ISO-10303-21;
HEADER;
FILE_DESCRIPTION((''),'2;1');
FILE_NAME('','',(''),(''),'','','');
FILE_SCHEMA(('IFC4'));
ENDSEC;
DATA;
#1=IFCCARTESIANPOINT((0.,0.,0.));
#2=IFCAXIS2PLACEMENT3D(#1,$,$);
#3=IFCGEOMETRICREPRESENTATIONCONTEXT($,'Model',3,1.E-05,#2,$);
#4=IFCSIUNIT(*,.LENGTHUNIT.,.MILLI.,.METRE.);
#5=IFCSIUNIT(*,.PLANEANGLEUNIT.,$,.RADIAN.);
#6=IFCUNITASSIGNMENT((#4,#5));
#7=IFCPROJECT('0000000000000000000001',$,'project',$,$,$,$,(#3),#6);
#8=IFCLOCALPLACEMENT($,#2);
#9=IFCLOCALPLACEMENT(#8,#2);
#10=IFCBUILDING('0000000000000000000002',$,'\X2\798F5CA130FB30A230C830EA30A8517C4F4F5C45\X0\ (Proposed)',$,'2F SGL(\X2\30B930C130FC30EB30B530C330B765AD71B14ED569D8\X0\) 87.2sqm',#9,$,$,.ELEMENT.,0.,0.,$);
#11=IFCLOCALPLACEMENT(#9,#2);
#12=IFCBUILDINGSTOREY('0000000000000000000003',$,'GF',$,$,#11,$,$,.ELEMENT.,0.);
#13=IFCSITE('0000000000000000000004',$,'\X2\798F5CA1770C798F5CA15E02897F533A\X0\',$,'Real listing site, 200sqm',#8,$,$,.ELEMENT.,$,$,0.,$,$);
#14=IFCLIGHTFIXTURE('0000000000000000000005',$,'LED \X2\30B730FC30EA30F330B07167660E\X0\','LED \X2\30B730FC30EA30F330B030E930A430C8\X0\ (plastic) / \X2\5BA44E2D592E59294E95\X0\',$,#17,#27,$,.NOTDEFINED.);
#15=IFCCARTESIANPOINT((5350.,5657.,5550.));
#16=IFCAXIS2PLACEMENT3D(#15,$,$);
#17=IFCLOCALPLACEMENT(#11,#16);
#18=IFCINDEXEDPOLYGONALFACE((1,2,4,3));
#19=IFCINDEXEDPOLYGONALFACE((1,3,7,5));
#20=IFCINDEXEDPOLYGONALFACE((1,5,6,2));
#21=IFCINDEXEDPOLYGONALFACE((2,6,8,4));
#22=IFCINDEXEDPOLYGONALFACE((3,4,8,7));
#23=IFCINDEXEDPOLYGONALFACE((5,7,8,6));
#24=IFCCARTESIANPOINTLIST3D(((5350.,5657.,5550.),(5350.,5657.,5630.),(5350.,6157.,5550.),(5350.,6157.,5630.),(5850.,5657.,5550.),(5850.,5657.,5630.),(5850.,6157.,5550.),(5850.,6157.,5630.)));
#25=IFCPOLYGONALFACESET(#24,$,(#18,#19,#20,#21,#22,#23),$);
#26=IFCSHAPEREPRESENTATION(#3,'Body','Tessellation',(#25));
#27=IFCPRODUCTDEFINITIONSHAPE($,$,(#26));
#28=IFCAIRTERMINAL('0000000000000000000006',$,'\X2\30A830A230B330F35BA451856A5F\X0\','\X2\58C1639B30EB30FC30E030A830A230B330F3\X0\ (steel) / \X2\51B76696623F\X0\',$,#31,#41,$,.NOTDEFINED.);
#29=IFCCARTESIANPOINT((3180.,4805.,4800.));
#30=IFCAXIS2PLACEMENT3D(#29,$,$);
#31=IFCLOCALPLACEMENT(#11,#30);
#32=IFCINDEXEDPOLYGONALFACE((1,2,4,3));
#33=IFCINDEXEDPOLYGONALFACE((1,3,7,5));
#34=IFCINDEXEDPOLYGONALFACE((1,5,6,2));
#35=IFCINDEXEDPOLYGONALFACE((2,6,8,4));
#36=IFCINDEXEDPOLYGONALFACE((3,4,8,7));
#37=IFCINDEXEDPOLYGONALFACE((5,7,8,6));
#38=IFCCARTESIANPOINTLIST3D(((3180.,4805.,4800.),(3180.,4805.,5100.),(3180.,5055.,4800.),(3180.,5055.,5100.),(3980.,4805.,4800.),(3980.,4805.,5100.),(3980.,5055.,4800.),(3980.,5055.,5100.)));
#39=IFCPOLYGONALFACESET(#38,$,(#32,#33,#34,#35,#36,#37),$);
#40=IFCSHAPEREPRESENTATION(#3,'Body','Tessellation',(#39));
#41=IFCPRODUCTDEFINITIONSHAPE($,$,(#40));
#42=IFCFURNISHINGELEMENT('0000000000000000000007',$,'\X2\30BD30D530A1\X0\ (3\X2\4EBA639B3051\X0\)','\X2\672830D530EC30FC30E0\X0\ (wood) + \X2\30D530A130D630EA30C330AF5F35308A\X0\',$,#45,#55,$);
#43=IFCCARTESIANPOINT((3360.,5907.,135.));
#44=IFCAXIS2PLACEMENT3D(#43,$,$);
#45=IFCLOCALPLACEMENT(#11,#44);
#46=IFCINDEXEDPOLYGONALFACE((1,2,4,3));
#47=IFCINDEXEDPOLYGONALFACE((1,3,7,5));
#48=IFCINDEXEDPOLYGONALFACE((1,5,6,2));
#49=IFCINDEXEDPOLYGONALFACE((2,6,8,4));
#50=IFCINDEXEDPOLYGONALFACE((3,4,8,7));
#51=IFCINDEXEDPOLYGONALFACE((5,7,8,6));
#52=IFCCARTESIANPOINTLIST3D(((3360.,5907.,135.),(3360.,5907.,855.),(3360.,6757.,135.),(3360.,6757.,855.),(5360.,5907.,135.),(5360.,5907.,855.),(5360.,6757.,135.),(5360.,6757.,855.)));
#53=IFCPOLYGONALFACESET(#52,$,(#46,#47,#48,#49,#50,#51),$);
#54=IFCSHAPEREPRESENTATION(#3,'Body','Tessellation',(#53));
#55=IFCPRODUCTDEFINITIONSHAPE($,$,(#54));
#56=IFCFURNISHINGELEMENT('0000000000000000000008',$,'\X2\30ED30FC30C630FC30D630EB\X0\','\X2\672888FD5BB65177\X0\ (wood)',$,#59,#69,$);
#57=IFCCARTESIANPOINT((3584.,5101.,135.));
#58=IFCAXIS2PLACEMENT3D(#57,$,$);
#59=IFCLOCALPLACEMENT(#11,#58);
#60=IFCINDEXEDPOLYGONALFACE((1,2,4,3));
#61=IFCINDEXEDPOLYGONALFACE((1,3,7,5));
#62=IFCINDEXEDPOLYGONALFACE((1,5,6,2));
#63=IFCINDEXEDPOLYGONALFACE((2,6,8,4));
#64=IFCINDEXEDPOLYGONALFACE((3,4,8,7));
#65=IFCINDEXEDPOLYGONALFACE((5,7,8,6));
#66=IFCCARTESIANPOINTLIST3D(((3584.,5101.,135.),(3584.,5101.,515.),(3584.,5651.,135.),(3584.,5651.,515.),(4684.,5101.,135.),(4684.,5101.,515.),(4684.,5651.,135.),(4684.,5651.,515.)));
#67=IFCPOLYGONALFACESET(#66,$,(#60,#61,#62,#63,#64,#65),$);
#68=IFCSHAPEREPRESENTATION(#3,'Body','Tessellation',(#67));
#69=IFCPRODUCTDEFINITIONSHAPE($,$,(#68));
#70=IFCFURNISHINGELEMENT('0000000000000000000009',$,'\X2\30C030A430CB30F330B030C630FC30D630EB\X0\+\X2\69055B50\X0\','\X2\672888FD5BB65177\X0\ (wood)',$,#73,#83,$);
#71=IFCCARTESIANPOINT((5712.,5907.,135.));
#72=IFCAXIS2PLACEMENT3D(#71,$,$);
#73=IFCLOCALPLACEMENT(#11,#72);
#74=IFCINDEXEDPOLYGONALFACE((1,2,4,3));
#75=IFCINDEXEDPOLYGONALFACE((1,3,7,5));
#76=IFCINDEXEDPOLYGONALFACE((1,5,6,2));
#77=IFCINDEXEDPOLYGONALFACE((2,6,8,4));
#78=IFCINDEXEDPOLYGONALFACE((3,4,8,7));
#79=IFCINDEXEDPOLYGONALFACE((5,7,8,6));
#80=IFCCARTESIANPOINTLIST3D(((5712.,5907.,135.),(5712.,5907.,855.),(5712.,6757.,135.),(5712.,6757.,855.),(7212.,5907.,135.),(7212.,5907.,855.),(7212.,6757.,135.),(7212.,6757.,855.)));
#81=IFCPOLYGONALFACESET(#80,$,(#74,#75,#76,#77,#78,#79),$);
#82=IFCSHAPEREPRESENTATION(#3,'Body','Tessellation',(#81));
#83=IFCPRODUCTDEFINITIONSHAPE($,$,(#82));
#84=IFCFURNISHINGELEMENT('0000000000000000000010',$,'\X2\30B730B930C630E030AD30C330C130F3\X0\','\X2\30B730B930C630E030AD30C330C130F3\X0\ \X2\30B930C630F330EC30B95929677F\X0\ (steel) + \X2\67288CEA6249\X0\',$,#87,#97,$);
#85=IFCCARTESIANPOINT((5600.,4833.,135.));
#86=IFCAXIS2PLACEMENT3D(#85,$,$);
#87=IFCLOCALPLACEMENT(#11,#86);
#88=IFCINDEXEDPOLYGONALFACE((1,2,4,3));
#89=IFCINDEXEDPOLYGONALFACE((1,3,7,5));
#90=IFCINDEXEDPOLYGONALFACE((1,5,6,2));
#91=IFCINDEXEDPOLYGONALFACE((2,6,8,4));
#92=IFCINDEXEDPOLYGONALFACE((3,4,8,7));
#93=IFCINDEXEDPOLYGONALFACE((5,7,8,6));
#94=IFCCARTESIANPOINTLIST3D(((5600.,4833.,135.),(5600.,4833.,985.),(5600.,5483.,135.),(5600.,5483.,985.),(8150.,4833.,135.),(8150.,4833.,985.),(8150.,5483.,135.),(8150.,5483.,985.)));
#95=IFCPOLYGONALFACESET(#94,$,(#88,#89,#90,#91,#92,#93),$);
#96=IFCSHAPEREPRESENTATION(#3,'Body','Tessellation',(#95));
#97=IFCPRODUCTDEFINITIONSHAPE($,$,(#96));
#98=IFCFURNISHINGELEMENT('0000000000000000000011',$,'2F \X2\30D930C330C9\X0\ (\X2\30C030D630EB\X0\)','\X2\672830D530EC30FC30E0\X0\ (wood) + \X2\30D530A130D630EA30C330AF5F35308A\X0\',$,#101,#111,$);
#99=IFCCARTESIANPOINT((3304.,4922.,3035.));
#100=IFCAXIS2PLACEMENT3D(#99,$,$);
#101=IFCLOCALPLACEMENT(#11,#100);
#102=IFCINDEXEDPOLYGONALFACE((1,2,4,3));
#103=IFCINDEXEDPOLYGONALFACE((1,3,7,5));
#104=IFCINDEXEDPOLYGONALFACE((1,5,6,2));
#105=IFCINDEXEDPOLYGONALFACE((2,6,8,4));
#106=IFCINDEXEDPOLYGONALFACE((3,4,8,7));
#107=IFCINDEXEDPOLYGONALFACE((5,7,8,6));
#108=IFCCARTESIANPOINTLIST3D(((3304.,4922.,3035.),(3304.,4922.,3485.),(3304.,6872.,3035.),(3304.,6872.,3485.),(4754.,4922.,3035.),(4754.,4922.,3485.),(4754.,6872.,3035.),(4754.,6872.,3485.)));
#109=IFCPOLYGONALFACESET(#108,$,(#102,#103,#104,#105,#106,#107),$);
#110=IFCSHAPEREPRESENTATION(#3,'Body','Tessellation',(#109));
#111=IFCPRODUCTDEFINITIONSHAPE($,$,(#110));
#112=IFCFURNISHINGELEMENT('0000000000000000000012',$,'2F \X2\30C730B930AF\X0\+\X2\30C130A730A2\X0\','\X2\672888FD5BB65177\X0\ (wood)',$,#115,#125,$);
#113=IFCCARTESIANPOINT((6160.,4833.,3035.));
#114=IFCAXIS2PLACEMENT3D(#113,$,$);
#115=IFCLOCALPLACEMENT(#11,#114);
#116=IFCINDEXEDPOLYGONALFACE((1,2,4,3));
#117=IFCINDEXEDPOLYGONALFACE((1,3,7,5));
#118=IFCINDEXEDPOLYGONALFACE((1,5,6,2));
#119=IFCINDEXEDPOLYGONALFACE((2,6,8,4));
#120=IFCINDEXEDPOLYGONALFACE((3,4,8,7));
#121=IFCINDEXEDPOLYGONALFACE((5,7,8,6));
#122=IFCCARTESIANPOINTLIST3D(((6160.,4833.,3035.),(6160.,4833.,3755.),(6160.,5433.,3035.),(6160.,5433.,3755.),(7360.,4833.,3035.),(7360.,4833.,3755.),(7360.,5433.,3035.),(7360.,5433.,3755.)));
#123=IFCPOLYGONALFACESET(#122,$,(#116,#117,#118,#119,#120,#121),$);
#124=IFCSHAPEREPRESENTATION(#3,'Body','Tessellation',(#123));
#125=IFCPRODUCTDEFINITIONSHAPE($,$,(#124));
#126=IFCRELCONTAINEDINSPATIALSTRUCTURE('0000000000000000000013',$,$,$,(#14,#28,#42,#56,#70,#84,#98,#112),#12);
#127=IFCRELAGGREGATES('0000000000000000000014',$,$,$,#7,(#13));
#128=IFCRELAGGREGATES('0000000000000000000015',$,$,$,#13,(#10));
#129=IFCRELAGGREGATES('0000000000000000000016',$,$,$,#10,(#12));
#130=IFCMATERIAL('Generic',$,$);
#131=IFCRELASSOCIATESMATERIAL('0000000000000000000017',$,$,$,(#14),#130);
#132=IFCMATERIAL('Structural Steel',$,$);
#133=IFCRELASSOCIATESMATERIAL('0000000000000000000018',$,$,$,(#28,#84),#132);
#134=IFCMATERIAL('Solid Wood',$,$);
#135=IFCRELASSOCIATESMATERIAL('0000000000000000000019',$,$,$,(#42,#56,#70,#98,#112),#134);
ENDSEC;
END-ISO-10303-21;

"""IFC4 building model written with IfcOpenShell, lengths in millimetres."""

from ifc_helpers import new_model, si_unit, frame, frame_2d, origin, place, context, project, spatial, rectangle, extrude, material, element, save


model = new_model("IFC4")

# Units and contexts
model_context = context("Model", 3, precision=1e-05, world=origin())
ifc_project = project(units=[si_unit("LENGTHUNIT", "METRE", prefix="MILLI"), si_unit("PLANEANGLEUNIT", "RADIAN")], contexts=[model_context])

# Site, building, storey
site_placement = place(None, origin())
site = spatial("IfcSite", under=ifc_project, at=site_placement, Name="福岡県福岡市西区", ObjectType="Real listing site, 200sqm", CompositionType="ELEMENT", RefElevation=0.0)
building_placement = place(site_placement, origin())
building = spatial("IfcBuilding", under=site, at=building_placement, Name="福岡・アトリエ兼住居 (Proposed)", ObjectType="2F SGL(スチールサッシ断熱仕様) 87.2sqm", CompositionType="ELEMENT", ElevationOfRefHeight=0.0, ElevationOfTerrain=0.0)
storey_placement = place(building_placement, origin())
storey = spatial("IfcBuildingStorey", under=building, at=storey_placement, Name="GF", CompositionType="ELEMENT", Elevation=0.0)

# Shared definitions
ifc_material_1 = material(Name="Solid Wood")

# Shared definitions
ifc_material_2 = material(Name="Generic")

# Shared definitions
ifc_material_3 = material(Name="Structural Steel")

# Light fixture
light_fixture_1_placement = place(storey_placement, frame((5350.0, 5657.0, 5550.0)))
element("IfcLightFixture", 1, at=light_fixture_1_placement, inside=storey, material=ifc_material_2, Name="LED シーリング照明", Description="LED シーリングライト (plastic) / 室中央天井", PredefinedType="NOTDEFINED", context=model_context, shape_type="SweptSolid", body=[
    extrude(rectangle(XDim=500.0, YDim=500.0, at=frame_2d((250.0, 250.0))), frame((5350.0, 5657.0, 5550.0)), (0.0, 0.0, 1.0), 80.0),
])

# Air terminal
air_terminal_placement = place(storey_placement, frame((3180.0, 4805.0, 4800.0)))
element("IfcAirTerminal", 2, at=air_terminal_placement, inside=storey, material=ifc_material_3, Name="エアコン室内機", Description="壁掛ルームエアコン (steel) / 冷暖房", PredefinedType="NOTDEFINED", context=model_context, shape_type="SweptSolid", body=[
    extrude(rectangle(XDim=800.0, YDim=250.0, at=frame_2d((400.0, 125.0))), frame((3180.0, 4805.0, 4800.0)), (0.0, 0.0, 1.0), 300.0),
])

# Furnishing elements
furnishing_1_placement = place(storey_placement, frame((3360.0, 5907.0, 135.0)))
element("IfcFurnishingElement", 3, at=furnishing_1_placement, inside=storey, material=ifc_material_1, Name="ソファ (3人掛け)", Description="木フレーム (wood) + ファブリック張り", context=model_context, shape_type="SweptSolid", body=[
    extrude(rectangle(XDim=2000.0, YDim=850.0, at=frame_2d((1000.0, 425.0))), frame((3360.0, 5907.0, 135.0)), (0.0, 0.0, 1.0), 720.0),
])
furnishing_2_placement = place(storey_placement, frame((3584.0, 5101.0, 135.0)))
element("IfcFurnishingElement", 4, at=furnishing_2_placement, inside=storey, material=ifc_material_1, Name="ローテーブル", Description="木製家具 (wood)", context=model_context, shape_type="SweptSolid", body=[
    extrude(rectangle(XDim=1100.0, YDim=550.0, at=frame_2d((550.0, 275.0))), frame((3584.0, 5101.0, 135.0)), (0.0, 0.0, 1.0), 380.0),
])
furnishing_3_placement = place(storey_placement, frame((5712.0, 5907.0, 135.0)))
element("IfcFurnishingElement", 5, at=furnishing_3_placement, inside=storey, material=ifc_material_1, Name="ダイニングテーブル+椅子", Description="木製家具 (wood)", context=model_context, shape_type="SweptSolid", body=[
    extrude(rectangle(XDim=1500.0, YDim=850.0, at=frame_2d((750.0, 425.0))), frame((5712.0, 5907.0, 135.0)), (0.0, 0.0, 1.0), 720.0),
])
furnishing_4_placement = place(storey_placement, frame((5600.0, 4833.0, 135.0)))
element("IfcFurnishingElement", 6, at=furnishing_4_placement, inside=storey, material=ifc_material_3, Name="システムキッチン", Description="システムキッチン ステンレス天板 (steel) + 木質扉", context=model_context, shape_type="SweptSolid", body=[
    extrude(rectangle(XDim=2550.0, YDim=650.0, at=frame_2d((1275.0, 325.0))), frame((5600.0, 4833.0, 135.0)), (0.0, 0.0, 1.0), 850.0),
])
furnishing_5_placement = place(storey_placement, frame((3304.0, 4922.0, 3035.0)))
element("IfcFurnishingElement", 7, at=furnishing_5_placement, inside=storey, material=ifc_material_1, Name="2F ベッド (ダブル)", Description="木フレーム (wood) + ファブリック張り", context=model_context, shape_type="SweptSolid", body=[
    extrude(rectangle(XDim=1450.0, YDim=1950.0, at=frame_2d((725.0, 975.0))), frame((3304.0, 4922.0, 3035.0)), (0.0, 0.0, 1.0), 450.0),
])
furnishing_6_placement = place(storey_placement, frame((6160.0, 4833.0, 3035.0)))
element("IfcFurnishingElement", 8, at=furnishing_6_placement, inside=storey, material=ifc_material_1, Name="2F デスク+チェア", Description="木製家具 (wood)", context=model_context, shape_type="SweptSolid", body=[
    extrude(rectangle(XDim=1200.0, YDim=600.0, at=frame_2d((600.0, 300.0))), frame((6160.0, 4833.0, 3035.0)), (0.0, 0.0, 1.0), 720.0),
])

save(model, "model.ifc")
